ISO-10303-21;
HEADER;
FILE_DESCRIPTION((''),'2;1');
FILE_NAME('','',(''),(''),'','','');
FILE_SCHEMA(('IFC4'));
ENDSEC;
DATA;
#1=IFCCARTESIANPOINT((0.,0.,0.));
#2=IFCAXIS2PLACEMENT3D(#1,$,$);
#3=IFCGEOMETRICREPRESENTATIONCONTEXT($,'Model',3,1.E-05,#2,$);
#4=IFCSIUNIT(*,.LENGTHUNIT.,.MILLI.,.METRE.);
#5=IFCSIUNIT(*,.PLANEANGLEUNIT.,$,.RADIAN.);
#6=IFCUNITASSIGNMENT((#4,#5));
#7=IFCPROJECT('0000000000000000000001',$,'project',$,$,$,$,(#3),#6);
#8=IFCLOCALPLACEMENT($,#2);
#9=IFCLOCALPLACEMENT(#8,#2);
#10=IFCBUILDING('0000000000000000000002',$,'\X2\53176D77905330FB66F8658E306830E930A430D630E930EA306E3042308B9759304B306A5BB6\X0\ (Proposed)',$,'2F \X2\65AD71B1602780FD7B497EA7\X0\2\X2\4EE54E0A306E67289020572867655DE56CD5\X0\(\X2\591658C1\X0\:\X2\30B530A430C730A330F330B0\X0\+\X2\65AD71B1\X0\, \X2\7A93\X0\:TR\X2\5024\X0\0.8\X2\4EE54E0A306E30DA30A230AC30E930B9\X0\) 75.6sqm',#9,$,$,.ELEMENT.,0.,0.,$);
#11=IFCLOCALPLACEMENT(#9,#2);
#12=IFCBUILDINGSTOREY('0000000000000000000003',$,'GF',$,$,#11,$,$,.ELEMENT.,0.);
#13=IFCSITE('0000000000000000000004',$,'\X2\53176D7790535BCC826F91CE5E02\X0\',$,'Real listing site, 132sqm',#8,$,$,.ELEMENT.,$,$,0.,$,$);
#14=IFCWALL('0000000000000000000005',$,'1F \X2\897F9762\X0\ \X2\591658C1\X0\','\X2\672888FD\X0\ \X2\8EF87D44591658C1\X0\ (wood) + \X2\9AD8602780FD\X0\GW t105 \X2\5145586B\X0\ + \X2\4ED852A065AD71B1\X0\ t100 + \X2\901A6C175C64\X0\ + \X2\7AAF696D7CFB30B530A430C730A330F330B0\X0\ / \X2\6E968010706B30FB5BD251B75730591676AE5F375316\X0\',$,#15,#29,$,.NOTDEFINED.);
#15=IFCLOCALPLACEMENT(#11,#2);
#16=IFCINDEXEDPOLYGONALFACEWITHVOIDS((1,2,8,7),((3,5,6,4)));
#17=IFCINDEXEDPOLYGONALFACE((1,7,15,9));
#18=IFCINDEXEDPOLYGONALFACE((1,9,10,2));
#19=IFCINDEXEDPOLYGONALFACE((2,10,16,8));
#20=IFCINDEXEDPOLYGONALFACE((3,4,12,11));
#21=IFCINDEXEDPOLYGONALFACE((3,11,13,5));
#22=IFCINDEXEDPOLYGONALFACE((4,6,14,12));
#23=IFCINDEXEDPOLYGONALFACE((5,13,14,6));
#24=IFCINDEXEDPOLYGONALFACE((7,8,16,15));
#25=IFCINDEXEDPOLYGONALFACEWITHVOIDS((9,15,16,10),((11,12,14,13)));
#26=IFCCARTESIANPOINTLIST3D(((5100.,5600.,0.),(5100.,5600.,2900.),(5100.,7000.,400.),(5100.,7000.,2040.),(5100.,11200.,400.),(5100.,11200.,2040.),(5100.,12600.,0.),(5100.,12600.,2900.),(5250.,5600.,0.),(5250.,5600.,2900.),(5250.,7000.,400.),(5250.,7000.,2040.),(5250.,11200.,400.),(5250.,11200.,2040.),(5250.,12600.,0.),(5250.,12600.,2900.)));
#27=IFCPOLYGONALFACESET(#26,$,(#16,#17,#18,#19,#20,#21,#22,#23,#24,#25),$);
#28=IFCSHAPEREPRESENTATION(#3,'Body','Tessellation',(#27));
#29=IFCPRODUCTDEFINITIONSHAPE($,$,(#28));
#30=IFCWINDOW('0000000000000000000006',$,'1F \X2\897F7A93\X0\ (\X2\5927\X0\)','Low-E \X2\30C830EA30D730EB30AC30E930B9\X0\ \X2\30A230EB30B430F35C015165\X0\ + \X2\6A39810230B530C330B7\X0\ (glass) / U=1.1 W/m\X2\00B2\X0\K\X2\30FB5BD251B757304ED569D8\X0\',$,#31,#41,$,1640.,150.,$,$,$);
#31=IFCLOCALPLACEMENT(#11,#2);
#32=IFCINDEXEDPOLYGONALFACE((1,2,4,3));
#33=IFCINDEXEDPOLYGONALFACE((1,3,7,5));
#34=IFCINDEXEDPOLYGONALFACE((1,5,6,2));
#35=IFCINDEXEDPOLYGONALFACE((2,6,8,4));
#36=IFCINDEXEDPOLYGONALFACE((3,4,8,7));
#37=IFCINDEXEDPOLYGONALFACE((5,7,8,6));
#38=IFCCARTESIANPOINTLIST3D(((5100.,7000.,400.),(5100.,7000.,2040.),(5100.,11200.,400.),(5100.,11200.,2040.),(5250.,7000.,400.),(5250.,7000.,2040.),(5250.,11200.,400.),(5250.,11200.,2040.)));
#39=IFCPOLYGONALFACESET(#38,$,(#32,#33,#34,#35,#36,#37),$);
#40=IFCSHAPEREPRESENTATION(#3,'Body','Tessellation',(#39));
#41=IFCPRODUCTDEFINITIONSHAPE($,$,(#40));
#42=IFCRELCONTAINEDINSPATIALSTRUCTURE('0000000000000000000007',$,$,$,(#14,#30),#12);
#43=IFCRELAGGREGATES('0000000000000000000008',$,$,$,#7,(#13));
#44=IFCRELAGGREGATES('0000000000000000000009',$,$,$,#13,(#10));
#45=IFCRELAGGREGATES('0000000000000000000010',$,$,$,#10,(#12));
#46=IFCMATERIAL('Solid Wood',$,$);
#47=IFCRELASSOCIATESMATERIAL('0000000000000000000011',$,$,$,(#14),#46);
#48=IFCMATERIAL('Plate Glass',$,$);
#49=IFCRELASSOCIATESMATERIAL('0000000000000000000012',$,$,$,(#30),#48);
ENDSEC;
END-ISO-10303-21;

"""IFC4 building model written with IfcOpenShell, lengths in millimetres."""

from ifc_helpers import new_model, si_unit, frame, frame_2d, origin, place, context, project, spatial, rectangle, extrude, material, element, fill, save


model = new_model("IFC4")

# Units and contexts
model_context = context("Model", 3, precision=1e-05, world=origin())
ifc_project = project(units=[si_unit("LENGTHUNIT", "METRE", prefix="MILLI"), si_unit("PLANEANGLEUNIT", "RADIAN")], contexts=[model_context])

# Site, building, storey
site_placement = place(None, origin())
site = spatial("IfcSite", under=ifc_project, at=site_placement, Name="北海道富良野市", ObjectType="Real listing site, 132sqm", CompositionType="ELEMENT", RefElevation=0.0)
building_placement = place(site_placement, origin())
building = spatial("IfcBuilding", under=site, at=building_placement, Name="北海道・書斎とライブラリのある静かな家 (Proposed)", ObjectType="2F 断熱性能等级2以上の木造在来工法(外壁:サイディング+断熱, 窓:TR値0.8以上のペアガラス) 75.6sqm", CompositionType="ELEMENT", ElevationOfRefHeight=0.0, ElevationOfTerrain=0.0)
storey_placement = place(building_placement, origin())
storey = spatial("IfcBuildingStorey", under=building, at=storey_placement, Name="GF", CompositionType="ELEMENT", Elevation=0.0)

# Shared definitions
ifc_material_1 = material(Name="Solid Wood")

# Shared definitions
ifc_material_2 = material(Name="Plate Glass")

# Wall, opening, window
wall_1_placement = place(storey_placement, frame((2550.0, 2800.0, 0.0)))
wall_1 = element("IfcWall", 1, at=wall_1_placement, inside=storey, material=ifc_material_1, Name="1F 西面 外壁", Description="木製 軸組外壁 (wood) + 高性能GW t105 充填 + 付加断熱 t100 + 通気層 + 窯業系サイディング / 準耐火・寒冷地外皮強化", PredefinedType="NOTDEFINED", context=model_context, shape_type="SweptSolid", body=[
    extrude(rectangle(XDim=150.0, YDim=7000.0, at=frame_2d((75.0, 3500.0))), frame((2550.0, 2800.0, 0.0)), (0.0, 0.0, 1.0), 2900.0),
])
opening_1_placement = place(storey_placement, frame((2550.0, 3500.0, 200.0)))
opening_1 = element("IfcOpeningElement", 2, at=opening_1_placement, cuts=wall_1, PredefinedType="NOTDEFINED", context=model_context, shape_type="SweptSolid", body=[
    extrude(rectangle(XDim=150.0, YDim=4200.0, at=frame_2d((75.0, 2100.0))), frame((2550.0, 3500.0, 200.0)), (0.0, 0.0, 1.0), 1640.0),
])
window_1_placement = place(storey_placement, frame((2550.0, 3500.0, 200.0)))
window_1 = element("IfcWindow", 3, at=window_1_placement, inside=storey, material=ifc_material_2, Name="1F 西窓 (大)", Description="Low-E トリプルガラス アルゴン封入 + 樹脂サッシ (glass) / U=1.1 W/m²K・寒冷地仕様", OverallHeight=1640.0, OverallWidth=150.0, context=model_context, shape_type="SweptSolid", body=[
    extrude(rectangle(XDim=150.0, YDim=4200.0, at=frame_2d((75.0, 2100.0))), frame((2550.0, 3500.0, 200.0)), (0.0, 0.0, 1.0), 1640.0),
])
fill(opening_1, window_1)

save(model, "model.ifc")
